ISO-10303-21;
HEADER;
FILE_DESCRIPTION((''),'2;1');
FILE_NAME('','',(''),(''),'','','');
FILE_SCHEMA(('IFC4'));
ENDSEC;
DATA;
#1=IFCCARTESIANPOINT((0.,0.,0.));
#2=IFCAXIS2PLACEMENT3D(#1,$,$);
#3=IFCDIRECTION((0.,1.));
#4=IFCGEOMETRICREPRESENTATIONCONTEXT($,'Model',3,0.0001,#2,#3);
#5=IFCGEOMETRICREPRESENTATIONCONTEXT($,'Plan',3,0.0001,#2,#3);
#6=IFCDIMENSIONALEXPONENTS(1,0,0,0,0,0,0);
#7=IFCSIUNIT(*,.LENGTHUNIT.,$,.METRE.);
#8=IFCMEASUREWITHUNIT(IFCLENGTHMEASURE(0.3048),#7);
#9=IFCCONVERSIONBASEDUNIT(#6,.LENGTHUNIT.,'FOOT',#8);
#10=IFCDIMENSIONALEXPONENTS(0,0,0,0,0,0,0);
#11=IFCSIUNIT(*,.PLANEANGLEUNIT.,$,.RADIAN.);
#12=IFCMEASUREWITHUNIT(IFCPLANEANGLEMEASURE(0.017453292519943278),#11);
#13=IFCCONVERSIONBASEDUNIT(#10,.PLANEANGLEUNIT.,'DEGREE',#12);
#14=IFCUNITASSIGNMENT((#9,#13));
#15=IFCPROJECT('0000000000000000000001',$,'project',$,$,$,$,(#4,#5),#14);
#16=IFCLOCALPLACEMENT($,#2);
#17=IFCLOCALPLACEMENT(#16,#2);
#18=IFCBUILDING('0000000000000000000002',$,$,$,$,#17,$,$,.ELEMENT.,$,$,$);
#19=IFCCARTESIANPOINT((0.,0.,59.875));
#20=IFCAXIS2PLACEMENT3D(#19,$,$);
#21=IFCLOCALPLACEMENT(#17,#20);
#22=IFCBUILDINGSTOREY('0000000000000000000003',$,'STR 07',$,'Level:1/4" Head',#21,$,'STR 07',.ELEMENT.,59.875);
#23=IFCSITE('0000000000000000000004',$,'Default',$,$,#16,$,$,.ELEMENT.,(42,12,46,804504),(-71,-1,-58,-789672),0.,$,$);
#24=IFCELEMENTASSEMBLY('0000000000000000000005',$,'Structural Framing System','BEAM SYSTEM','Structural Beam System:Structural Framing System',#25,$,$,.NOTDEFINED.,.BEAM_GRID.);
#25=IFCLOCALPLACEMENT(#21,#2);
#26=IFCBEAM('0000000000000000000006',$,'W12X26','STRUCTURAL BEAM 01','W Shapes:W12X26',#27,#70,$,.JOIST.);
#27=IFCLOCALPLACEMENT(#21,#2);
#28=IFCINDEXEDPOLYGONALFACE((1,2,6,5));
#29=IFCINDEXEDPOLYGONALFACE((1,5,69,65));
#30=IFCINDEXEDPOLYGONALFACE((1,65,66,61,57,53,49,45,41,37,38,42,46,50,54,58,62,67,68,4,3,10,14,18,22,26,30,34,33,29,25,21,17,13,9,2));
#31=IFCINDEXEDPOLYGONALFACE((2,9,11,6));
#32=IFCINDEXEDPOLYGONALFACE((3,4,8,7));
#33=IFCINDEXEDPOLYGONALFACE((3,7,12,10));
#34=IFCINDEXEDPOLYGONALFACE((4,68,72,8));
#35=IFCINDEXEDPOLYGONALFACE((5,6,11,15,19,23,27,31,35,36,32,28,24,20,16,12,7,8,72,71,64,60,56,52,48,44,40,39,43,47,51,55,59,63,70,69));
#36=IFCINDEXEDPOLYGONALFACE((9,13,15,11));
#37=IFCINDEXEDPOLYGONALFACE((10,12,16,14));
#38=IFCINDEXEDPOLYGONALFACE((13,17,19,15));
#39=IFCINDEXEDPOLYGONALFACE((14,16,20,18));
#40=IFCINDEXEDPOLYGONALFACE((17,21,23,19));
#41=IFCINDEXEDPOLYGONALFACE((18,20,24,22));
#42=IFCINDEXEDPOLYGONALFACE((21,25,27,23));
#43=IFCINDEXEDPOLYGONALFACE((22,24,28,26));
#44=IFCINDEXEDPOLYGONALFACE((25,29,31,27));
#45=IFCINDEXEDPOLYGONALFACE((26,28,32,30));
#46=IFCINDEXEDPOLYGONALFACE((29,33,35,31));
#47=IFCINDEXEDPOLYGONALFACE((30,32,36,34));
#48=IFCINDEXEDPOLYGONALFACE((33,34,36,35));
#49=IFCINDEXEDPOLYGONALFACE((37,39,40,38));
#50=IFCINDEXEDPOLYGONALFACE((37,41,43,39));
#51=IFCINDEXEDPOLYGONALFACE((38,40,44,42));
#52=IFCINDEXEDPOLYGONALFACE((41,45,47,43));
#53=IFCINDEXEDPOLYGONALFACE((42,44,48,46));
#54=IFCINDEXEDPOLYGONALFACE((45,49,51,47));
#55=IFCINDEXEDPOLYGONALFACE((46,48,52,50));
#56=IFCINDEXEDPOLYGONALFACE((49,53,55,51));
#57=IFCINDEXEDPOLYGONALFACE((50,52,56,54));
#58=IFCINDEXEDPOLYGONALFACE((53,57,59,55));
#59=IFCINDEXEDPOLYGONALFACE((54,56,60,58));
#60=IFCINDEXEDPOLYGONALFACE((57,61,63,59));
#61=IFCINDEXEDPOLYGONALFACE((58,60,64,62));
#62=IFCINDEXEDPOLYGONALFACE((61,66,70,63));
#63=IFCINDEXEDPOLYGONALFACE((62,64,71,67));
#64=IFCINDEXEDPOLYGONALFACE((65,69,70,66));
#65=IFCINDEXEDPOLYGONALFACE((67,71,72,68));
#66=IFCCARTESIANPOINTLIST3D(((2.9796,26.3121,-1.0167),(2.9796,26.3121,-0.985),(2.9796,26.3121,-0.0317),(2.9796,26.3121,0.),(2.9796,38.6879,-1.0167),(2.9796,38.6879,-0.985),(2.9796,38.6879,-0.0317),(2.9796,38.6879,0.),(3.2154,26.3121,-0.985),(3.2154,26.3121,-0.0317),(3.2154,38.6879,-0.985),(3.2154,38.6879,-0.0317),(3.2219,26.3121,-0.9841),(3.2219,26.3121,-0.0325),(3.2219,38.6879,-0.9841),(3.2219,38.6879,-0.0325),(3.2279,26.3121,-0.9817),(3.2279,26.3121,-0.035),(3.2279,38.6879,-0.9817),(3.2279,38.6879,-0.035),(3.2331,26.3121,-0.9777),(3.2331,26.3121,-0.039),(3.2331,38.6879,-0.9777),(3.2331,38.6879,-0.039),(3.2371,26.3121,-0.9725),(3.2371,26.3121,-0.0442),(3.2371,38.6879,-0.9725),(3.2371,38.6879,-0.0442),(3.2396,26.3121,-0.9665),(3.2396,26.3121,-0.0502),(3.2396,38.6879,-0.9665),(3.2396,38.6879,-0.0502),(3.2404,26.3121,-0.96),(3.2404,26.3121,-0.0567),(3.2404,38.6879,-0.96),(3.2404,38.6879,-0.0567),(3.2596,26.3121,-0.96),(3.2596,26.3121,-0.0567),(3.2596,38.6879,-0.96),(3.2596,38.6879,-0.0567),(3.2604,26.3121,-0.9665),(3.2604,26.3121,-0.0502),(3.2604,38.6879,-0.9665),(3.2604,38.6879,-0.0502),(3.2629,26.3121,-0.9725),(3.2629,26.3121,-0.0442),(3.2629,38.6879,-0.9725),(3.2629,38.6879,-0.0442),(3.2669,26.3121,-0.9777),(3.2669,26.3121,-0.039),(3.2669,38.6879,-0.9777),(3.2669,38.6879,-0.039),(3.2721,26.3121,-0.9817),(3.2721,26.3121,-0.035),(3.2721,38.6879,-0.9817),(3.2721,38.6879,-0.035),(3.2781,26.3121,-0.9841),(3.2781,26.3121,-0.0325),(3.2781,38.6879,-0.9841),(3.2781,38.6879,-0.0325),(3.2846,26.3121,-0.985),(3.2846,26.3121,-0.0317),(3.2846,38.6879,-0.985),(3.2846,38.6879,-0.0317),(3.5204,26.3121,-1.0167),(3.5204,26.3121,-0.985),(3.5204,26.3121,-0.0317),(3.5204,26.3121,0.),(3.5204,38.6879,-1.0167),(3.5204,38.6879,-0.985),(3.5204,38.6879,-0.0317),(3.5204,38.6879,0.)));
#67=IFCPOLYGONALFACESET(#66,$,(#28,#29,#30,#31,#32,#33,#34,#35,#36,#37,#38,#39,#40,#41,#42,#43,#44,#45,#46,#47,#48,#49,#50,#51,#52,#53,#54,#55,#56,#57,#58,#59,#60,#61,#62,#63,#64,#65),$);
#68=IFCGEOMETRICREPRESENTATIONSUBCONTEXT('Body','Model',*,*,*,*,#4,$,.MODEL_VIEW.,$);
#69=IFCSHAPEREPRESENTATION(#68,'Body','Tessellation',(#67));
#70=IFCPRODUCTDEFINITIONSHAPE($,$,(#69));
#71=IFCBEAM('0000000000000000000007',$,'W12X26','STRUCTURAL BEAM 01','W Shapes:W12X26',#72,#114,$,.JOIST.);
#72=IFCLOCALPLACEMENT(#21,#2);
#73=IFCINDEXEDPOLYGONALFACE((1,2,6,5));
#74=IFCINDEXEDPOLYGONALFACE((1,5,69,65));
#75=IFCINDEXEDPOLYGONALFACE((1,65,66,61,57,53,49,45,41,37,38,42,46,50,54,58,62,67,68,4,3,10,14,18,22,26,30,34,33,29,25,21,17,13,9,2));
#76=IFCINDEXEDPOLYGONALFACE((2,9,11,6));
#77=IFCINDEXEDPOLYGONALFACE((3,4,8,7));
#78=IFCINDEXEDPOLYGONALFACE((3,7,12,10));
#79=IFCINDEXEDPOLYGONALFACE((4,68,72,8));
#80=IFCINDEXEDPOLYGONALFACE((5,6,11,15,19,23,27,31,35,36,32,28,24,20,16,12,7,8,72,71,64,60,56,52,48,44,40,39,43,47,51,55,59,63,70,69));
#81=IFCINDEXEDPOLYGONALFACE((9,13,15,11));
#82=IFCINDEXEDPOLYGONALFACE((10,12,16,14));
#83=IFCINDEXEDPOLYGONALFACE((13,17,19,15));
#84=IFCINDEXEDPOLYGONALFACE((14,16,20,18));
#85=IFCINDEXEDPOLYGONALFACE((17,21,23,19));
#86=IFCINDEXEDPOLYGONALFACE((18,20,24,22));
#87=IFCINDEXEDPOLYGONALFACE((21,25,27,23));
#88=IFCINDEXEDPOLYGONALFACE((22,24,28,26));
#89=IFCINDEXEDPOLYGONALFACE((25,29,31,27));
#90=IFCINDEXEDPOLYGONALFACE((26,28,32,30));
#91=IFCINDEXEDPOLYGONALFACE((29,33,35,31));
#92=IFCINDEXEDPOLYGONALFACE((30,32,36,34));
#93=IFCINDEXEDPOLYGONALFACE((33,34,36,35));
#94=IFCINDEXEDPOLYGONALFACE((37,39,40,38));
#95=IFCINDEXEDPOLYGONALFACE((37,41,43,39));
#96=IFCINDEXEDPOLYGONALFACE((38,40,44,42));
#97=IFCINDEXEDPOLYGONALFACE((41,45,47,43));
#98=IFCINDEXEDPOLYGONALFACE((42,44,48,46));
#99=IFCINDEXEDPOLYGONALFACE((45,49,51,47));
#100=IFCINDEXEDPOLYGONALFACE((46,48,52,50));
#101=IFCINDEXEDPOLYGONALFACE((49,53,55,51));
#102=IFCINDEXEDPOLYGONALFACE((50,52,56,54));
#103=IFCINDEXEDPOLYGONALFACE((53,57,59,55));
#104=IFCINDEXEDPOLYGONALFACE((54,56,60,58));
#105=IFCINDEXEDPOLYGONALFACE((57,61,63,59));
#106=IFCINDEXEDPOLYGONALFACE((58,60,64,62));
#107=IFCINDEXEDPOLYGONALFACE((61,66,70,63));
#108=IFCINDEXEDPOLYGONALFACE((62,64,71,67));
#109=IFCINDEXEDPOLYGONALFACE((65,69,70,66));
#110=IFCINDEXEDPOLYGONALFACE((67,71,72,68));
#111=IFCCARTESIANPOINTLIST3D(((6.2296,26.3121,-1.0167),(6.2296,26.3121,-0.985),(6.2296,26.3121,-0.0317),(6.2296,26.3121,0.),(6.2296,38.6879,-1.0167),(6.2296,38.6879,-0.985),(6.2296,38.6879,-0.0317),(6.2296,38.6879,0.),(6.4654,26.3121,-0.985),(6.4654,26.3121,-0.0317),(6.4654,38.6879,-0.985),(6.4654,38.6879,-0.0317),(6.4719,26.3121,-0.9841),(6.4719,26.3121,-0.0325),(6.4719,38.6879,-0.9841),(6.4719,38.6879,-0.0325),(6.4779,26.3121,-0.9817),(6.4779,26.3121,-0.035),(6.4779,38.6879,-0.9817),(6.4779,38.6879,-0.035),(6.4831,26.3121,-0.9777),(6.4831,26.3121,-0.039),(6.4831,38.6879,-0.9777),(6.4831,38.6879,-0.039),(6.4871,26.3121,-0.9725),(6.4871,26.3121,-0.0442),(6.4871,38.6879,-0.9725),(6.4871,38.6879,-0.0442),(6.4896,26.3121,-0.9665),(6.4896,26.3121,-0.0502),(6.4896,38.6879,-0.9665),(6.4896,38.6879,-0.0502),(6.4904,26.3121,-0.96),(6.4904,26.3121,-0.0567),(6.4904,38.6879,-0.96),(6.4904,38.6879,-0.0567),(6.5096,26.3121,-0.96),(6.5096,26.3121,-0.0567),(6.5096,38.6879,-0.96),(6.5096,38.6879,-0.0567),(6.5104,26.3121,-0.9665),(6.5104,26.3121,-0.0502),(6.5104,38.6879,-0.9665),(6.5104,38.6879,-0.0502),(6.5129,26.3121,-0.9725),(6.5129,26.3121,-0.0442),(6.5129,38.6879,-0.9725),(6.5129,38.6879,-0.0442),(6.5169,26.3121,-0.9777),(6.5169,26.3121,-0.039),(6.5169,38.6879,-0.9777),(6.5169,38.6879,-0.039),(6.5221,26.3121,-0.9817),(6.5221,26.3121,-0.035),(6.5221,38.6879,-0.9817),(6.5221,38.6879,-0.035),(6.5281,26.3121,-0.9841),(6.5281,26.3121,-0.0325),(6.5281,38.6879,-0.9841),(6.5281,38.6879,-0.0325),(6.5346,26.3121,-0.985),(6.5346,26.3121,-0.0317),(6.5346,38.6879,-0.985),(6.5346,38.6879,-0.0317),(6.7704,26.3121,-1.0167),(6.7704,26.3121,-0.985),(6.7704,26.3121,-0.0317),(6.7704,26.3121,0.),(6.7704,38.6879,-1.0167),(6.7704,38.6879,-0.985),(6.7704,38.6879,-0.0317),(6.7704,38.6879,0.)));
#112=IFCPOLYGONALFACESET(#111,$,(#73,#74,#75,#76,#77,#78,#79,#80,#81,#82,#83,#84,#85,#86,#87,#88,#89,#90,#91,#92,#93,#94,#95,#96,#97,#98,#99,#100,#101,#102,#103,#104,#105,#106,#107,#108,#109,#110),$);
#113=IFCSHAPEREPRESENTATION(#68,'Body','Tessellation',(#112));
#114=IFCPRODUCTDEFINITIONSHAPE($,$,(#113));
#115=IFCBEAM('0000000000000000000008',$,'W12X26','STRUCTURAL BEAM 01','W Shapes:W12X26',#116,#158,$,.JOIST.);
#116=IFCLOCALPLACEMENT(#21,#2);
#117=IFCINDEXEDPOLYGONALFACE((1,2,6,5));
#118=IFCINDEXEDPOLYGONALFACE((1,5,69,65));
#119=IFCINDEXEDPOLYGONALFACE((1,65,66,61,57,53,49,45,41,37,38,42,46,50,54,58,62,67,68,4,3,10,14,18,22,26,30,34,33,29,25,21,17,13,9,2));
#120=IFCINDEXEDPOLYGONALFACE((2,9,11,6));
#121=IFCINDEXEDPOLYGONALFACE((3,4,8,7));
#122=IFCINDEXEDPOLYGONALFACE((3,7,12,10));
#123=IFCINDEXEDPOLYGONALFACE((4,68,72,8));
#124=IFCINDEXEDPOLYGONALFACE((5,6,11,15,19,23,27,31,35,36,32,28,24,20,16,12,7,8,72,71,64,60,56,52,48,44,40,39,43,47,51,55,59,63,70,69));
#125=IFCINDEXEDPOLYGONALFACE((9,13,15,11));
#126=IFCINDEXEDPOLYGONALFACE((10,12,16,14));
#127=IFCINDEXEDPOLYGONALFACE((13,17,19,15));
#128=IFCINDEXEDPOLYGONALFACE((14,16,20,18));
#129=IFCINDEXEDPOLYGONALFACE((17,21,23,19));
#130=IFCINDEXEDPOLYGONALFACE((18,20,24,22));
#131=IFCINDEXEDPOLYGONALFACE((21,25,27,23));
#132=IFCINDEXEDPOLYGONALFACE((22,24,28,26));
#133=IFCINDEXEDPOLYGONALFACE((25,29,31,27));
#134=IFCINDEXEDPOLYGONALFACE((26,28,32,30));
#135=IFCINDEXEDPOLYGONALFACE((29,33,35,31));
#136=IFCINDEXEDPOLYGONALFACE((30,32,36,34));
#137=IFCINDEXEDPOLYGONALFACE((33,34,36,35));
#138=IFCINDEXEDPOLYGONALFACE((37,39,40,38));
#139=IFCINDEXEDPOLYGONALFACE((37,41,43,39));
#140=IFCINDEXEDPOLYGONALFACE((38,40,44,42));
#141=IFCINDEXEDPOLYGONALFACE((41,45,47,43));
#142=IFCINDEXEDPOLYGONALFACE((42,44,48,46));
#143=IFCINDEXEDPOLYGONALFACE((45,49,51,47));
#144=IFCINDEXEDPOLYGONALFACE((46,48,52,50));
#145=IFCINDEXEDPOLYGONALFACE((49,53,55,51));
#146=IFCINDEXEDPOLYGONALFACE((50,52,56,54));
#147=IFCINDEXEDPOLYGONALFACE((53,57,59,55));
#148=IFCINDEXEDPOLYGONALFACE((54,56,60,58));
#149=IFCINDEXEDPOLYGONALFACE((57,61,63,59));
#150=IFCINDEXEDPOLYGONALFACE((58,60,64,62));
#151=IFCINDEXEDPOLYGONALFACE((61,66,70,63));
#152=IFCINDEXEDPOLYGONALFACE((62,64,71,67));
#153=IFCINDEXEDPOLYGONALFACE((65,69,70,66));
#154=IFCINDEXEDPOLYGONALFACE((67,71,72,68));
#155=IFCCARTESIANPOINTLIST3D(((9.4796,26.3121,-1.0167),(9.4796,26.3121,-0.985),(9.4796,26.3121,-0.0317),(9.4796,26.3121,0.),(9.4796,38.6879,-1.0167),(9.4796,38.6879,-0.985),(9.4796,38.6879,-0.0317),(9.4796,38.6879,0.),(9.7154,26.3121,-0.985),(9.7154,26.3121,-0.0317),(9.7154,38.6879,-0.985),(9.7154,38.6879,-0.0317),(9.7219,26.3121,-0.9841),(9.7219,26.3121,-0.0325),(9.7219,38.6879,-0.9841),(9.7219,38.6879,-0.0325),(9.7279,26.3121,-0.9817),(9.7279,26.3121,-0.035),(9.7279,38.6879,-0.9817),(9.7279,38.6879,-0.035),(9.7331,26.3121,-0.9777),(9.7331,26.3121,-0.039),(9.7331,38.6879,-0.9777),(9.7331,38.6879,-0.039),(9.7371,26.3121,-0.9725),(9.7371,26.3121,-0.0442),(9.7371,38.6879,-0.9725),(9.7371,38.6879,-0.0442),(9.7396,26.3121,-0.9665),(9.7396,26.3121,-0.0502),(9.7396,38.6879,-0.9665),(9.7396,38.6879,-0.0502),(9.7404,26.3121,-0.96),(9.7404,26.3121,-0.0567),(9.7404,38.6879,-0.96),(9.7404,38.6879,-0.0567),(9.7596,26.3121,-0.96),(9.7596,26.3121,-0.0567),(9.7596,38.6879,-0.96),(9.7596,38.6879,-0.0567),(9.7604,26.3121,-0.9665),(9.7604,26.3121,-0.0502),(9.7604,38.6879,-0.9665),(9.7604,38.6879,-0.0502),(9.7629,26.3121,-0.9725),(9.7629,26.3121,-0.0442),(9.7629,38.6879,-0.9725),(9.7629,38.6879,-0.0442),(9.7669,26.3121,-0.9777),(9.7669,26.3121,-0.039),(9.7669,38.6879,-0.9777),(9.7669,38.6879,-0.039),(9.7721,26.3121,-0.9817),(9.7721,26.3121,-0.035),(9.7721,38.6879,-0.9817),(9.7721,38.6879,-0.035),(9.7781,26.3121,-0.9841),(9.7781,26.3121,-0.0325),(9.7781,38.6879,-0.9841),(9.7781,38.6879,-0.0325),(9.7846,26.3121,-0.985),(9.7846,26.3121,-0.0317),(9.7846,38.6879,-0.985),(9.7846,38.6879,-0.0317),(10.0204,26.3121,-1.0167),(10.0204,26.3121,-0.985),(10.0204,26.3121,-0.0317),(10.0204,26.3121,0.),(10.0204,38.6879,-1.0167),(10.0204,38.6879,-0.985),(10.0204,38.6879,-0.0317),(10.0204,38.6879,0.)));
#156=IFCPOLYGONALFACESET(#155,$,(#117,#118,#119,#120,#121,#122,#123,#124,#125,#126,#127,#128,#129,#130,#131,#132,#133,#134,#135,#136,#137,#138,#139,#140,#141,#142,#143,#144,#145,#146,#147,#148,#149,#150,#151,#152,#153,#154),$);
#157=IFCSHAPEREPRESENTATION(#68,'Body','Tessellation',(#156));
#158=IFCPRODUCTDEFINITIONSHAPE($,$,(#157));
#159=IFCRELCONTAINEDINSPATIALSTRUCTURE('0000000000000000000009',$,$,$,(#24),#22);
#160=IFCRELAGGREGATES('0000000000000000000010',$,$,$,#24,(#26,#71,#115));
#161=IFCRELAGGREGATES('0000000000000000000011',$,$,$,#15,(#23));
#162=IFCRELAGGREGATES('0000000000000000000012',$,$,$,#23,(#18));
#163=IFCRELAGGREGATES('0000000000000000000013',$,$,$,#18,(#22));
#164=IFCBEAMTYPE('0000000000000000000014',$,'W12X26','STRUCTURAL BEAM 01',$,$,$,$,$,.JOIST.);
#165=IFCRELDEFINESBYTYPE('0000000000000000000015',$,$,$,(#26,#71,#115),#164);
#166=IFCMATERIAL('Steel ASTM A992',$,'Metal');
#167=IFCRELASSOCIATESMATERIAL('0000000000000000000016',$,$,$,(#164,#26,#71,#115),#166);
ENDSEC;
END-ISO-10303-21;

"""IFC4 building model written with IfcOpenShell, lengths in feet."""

from ifc_helpers import new_model, entity, si_unit, converted_unit, direction, frame, origin, place, context, subcontext, project, spatial, line, arc, indexed_curve, outline, extrude, source, transform, mapped, material, type_object, type_shapes, element, aggregate, save


model = new_model("IFC4")

# Units and contexts
model_context = context("Model", 3, precision=0.0001, world=origin(), true_north=direction((0.0, 1.0)))
plan_context = context("Plan", 3, precision=0.0001, world=origin(), true_north=direction((0.0, 1.0)))
body_context = subcontext(model_context, "Body", "Model", "MODEL_VIEW")
ifc_project = project(units=[converted_unit("LENGTHUNIT", "FOOT", entity("IfcLengthMeasure", 0.3048), si_unit("LENGTHUNIT", "METRE"), dimensions=[1, 0, 0, 0, 0, 0, 0]), converted_unit("PLANEANGLEUNIT", "DEGREE", entity("IfcPlaneAngleMeasure", 0.017453292519943278), si_unit("PLANEANGLEUNIT", "RADIAN"), dimensions=[0, 0, 0, 0, 0, 0, 0])], contexts=[model_context, plan_context])

# Site, building, storey
site_placement = place(None, origin())
site = spatial("IfcSite", under=ifc_project, at=site_placement, Name="Default", CompositionType="ELEMENT", RefLatitude=(42, 12, 46, 804504), RefLongitude=(-71, -1, -58, -789672), RefElevation=0.0)
building_placement = place(site_placement, origin())
building = spatial("IfcBuilding", under=site, at=building_placement, CompositionType="ELEMENT")
storey_placement = place(building_placement, frame((0.0, 0.0, 59.875)))
storey = spatial("IfcBuildingStorey", under=building, at=storey_placement, Name="STR 07", ObjectType="Level:1/4\" Head", LongName="STR 07", CompositionType="ELEMENT", Elevation=59.875)

# Element assembly, beams
ifc_material = material(Name="Steel ASTM A992", Category="Metal")
beam_type_1 = type_object("IfcBeamType", Name="W12X26", Description="STRUCTURAL BEAM 01", PredefinedType="JOIST", material=ifc_material)
shared_shape = source(origin(), body_context, "Body", "SweptSolid", [
    extrude(outline(indexed_curve([(-0.2704, -0.4767), (-0.2704, -0.5083), (0.2704, -0.5083), (0.2704, -0.4767), (0.0346, -0.4767), (0.0169, -0.4693), (0.0096, -0.4517), (0.0096, 0.4517), (0.0169, 0.4693), (0.0346, 0.4767), (0.2704, 0.4767), (0.2704, 0.5083), (-0.2704, 0.5083), (-0.2704, 0.4767), (-0.0346, 0.4767), (-0.0169, 0.4693), (-0.0096, 0.4517), (-0.0096, -0.4517), (-0.0169, -0.4693), (-0.0346, -0.4767)], segments=[line(1, 2, 3, 4, 5), arc(5, 6, 7), line(7, 8), arc(8, 9, 10), line(10, 11, 12, 13, 14, 15), arc(15, 16, 17), line(17, 18), arc(18, 19, 20), line(20, 1)], self_intersect=False)), frame((-6.1879, 0.0, 0.0), z_axis=(-1.0, 0.0, 0.0), x_axis=(0.0, -1.0, 0.0)), (0.0, 0.0, -1.0), 12.3758),
])
type_shapes(beam_type_1, [shared_shape])
assembly_1_placement = place(storey_placement, origin())
assembly_1 = element("IfcElementAssembly", 1, at=assembly_1_placement, inside=storey, Name="Structural Framing System", Description="BEAM SYSTEM", ObjectType="Structural Beam System:Structural Framing System", AssemblyPlace="NOTDEFINED", PredefinedType="BEAM_GRID")
beam_1_placement = place(assembly_1_placement, frame((3.25, 32.5, -0.5083), z_axis=(0.0, 0.0, 1.0), x_axis=(0.0, 1.0, 0.0)))
beam_1 = element("IfcBeam", 2, at=beam_1_placement, type_object=beam_type_1, material=ifc_material, Name="W12X26", Description="STRUCTURAL BEAM 01", ObjectType="W Shapes:W12X26", PredefinedType="JOIST", context=body_context, shape_type="MappedRepresentation", body=[
    mapped(shared_shape, transform((0.0, 0.0, 0.0), scale=1.0)),
])
beam_2_placement = place(assembly_1_placement, frame((6.5, 32.5, -0.5083), z_axis=(0.0, 0.0, 1.0), x_axis=(0.0, 1.0, 0.0)))
beam_2 = element("IfcBeam", 3, at=beam_2_placement, type_object=beam_type_1, material=ifc_material, Name="W12X26", Description="STRUCTURAL BEAM 01", ObjectType="W Shapes:W12X26", PredefinedType="JOIST", context=body_context, shape_type="MappedRepresentation", body=[
    mapped(shared_shape, transform((0.0, 0.0, 0.0), scale=1.0)),
])
beam_3_placement = place(assembly_1_placement, frame((9.75, 32.5, -0.5083), z_axis=(0.0, 0.0, 1.0), x_axis=(0.0, 1.0, 0.0)))
beam_3 = element("IfcBeam", 4, at=beam_3_placement, type_object=beam_type_1, material=ifc_material, Name="W12X26", Description="STRUCTURAL BEAM 01", ObjectType="W Shapes:W12X26", PredefinedType="JOIST", context=body_context, shape_type="MappedRepresentation", body=[
    mapped(shared_shape, transform((0.0, 0.0, 0.0), scale=1.0)),
])
aggregate(assembly_1, [beam_1, beam_2, beam_3])

save(model, "model.ifc")
